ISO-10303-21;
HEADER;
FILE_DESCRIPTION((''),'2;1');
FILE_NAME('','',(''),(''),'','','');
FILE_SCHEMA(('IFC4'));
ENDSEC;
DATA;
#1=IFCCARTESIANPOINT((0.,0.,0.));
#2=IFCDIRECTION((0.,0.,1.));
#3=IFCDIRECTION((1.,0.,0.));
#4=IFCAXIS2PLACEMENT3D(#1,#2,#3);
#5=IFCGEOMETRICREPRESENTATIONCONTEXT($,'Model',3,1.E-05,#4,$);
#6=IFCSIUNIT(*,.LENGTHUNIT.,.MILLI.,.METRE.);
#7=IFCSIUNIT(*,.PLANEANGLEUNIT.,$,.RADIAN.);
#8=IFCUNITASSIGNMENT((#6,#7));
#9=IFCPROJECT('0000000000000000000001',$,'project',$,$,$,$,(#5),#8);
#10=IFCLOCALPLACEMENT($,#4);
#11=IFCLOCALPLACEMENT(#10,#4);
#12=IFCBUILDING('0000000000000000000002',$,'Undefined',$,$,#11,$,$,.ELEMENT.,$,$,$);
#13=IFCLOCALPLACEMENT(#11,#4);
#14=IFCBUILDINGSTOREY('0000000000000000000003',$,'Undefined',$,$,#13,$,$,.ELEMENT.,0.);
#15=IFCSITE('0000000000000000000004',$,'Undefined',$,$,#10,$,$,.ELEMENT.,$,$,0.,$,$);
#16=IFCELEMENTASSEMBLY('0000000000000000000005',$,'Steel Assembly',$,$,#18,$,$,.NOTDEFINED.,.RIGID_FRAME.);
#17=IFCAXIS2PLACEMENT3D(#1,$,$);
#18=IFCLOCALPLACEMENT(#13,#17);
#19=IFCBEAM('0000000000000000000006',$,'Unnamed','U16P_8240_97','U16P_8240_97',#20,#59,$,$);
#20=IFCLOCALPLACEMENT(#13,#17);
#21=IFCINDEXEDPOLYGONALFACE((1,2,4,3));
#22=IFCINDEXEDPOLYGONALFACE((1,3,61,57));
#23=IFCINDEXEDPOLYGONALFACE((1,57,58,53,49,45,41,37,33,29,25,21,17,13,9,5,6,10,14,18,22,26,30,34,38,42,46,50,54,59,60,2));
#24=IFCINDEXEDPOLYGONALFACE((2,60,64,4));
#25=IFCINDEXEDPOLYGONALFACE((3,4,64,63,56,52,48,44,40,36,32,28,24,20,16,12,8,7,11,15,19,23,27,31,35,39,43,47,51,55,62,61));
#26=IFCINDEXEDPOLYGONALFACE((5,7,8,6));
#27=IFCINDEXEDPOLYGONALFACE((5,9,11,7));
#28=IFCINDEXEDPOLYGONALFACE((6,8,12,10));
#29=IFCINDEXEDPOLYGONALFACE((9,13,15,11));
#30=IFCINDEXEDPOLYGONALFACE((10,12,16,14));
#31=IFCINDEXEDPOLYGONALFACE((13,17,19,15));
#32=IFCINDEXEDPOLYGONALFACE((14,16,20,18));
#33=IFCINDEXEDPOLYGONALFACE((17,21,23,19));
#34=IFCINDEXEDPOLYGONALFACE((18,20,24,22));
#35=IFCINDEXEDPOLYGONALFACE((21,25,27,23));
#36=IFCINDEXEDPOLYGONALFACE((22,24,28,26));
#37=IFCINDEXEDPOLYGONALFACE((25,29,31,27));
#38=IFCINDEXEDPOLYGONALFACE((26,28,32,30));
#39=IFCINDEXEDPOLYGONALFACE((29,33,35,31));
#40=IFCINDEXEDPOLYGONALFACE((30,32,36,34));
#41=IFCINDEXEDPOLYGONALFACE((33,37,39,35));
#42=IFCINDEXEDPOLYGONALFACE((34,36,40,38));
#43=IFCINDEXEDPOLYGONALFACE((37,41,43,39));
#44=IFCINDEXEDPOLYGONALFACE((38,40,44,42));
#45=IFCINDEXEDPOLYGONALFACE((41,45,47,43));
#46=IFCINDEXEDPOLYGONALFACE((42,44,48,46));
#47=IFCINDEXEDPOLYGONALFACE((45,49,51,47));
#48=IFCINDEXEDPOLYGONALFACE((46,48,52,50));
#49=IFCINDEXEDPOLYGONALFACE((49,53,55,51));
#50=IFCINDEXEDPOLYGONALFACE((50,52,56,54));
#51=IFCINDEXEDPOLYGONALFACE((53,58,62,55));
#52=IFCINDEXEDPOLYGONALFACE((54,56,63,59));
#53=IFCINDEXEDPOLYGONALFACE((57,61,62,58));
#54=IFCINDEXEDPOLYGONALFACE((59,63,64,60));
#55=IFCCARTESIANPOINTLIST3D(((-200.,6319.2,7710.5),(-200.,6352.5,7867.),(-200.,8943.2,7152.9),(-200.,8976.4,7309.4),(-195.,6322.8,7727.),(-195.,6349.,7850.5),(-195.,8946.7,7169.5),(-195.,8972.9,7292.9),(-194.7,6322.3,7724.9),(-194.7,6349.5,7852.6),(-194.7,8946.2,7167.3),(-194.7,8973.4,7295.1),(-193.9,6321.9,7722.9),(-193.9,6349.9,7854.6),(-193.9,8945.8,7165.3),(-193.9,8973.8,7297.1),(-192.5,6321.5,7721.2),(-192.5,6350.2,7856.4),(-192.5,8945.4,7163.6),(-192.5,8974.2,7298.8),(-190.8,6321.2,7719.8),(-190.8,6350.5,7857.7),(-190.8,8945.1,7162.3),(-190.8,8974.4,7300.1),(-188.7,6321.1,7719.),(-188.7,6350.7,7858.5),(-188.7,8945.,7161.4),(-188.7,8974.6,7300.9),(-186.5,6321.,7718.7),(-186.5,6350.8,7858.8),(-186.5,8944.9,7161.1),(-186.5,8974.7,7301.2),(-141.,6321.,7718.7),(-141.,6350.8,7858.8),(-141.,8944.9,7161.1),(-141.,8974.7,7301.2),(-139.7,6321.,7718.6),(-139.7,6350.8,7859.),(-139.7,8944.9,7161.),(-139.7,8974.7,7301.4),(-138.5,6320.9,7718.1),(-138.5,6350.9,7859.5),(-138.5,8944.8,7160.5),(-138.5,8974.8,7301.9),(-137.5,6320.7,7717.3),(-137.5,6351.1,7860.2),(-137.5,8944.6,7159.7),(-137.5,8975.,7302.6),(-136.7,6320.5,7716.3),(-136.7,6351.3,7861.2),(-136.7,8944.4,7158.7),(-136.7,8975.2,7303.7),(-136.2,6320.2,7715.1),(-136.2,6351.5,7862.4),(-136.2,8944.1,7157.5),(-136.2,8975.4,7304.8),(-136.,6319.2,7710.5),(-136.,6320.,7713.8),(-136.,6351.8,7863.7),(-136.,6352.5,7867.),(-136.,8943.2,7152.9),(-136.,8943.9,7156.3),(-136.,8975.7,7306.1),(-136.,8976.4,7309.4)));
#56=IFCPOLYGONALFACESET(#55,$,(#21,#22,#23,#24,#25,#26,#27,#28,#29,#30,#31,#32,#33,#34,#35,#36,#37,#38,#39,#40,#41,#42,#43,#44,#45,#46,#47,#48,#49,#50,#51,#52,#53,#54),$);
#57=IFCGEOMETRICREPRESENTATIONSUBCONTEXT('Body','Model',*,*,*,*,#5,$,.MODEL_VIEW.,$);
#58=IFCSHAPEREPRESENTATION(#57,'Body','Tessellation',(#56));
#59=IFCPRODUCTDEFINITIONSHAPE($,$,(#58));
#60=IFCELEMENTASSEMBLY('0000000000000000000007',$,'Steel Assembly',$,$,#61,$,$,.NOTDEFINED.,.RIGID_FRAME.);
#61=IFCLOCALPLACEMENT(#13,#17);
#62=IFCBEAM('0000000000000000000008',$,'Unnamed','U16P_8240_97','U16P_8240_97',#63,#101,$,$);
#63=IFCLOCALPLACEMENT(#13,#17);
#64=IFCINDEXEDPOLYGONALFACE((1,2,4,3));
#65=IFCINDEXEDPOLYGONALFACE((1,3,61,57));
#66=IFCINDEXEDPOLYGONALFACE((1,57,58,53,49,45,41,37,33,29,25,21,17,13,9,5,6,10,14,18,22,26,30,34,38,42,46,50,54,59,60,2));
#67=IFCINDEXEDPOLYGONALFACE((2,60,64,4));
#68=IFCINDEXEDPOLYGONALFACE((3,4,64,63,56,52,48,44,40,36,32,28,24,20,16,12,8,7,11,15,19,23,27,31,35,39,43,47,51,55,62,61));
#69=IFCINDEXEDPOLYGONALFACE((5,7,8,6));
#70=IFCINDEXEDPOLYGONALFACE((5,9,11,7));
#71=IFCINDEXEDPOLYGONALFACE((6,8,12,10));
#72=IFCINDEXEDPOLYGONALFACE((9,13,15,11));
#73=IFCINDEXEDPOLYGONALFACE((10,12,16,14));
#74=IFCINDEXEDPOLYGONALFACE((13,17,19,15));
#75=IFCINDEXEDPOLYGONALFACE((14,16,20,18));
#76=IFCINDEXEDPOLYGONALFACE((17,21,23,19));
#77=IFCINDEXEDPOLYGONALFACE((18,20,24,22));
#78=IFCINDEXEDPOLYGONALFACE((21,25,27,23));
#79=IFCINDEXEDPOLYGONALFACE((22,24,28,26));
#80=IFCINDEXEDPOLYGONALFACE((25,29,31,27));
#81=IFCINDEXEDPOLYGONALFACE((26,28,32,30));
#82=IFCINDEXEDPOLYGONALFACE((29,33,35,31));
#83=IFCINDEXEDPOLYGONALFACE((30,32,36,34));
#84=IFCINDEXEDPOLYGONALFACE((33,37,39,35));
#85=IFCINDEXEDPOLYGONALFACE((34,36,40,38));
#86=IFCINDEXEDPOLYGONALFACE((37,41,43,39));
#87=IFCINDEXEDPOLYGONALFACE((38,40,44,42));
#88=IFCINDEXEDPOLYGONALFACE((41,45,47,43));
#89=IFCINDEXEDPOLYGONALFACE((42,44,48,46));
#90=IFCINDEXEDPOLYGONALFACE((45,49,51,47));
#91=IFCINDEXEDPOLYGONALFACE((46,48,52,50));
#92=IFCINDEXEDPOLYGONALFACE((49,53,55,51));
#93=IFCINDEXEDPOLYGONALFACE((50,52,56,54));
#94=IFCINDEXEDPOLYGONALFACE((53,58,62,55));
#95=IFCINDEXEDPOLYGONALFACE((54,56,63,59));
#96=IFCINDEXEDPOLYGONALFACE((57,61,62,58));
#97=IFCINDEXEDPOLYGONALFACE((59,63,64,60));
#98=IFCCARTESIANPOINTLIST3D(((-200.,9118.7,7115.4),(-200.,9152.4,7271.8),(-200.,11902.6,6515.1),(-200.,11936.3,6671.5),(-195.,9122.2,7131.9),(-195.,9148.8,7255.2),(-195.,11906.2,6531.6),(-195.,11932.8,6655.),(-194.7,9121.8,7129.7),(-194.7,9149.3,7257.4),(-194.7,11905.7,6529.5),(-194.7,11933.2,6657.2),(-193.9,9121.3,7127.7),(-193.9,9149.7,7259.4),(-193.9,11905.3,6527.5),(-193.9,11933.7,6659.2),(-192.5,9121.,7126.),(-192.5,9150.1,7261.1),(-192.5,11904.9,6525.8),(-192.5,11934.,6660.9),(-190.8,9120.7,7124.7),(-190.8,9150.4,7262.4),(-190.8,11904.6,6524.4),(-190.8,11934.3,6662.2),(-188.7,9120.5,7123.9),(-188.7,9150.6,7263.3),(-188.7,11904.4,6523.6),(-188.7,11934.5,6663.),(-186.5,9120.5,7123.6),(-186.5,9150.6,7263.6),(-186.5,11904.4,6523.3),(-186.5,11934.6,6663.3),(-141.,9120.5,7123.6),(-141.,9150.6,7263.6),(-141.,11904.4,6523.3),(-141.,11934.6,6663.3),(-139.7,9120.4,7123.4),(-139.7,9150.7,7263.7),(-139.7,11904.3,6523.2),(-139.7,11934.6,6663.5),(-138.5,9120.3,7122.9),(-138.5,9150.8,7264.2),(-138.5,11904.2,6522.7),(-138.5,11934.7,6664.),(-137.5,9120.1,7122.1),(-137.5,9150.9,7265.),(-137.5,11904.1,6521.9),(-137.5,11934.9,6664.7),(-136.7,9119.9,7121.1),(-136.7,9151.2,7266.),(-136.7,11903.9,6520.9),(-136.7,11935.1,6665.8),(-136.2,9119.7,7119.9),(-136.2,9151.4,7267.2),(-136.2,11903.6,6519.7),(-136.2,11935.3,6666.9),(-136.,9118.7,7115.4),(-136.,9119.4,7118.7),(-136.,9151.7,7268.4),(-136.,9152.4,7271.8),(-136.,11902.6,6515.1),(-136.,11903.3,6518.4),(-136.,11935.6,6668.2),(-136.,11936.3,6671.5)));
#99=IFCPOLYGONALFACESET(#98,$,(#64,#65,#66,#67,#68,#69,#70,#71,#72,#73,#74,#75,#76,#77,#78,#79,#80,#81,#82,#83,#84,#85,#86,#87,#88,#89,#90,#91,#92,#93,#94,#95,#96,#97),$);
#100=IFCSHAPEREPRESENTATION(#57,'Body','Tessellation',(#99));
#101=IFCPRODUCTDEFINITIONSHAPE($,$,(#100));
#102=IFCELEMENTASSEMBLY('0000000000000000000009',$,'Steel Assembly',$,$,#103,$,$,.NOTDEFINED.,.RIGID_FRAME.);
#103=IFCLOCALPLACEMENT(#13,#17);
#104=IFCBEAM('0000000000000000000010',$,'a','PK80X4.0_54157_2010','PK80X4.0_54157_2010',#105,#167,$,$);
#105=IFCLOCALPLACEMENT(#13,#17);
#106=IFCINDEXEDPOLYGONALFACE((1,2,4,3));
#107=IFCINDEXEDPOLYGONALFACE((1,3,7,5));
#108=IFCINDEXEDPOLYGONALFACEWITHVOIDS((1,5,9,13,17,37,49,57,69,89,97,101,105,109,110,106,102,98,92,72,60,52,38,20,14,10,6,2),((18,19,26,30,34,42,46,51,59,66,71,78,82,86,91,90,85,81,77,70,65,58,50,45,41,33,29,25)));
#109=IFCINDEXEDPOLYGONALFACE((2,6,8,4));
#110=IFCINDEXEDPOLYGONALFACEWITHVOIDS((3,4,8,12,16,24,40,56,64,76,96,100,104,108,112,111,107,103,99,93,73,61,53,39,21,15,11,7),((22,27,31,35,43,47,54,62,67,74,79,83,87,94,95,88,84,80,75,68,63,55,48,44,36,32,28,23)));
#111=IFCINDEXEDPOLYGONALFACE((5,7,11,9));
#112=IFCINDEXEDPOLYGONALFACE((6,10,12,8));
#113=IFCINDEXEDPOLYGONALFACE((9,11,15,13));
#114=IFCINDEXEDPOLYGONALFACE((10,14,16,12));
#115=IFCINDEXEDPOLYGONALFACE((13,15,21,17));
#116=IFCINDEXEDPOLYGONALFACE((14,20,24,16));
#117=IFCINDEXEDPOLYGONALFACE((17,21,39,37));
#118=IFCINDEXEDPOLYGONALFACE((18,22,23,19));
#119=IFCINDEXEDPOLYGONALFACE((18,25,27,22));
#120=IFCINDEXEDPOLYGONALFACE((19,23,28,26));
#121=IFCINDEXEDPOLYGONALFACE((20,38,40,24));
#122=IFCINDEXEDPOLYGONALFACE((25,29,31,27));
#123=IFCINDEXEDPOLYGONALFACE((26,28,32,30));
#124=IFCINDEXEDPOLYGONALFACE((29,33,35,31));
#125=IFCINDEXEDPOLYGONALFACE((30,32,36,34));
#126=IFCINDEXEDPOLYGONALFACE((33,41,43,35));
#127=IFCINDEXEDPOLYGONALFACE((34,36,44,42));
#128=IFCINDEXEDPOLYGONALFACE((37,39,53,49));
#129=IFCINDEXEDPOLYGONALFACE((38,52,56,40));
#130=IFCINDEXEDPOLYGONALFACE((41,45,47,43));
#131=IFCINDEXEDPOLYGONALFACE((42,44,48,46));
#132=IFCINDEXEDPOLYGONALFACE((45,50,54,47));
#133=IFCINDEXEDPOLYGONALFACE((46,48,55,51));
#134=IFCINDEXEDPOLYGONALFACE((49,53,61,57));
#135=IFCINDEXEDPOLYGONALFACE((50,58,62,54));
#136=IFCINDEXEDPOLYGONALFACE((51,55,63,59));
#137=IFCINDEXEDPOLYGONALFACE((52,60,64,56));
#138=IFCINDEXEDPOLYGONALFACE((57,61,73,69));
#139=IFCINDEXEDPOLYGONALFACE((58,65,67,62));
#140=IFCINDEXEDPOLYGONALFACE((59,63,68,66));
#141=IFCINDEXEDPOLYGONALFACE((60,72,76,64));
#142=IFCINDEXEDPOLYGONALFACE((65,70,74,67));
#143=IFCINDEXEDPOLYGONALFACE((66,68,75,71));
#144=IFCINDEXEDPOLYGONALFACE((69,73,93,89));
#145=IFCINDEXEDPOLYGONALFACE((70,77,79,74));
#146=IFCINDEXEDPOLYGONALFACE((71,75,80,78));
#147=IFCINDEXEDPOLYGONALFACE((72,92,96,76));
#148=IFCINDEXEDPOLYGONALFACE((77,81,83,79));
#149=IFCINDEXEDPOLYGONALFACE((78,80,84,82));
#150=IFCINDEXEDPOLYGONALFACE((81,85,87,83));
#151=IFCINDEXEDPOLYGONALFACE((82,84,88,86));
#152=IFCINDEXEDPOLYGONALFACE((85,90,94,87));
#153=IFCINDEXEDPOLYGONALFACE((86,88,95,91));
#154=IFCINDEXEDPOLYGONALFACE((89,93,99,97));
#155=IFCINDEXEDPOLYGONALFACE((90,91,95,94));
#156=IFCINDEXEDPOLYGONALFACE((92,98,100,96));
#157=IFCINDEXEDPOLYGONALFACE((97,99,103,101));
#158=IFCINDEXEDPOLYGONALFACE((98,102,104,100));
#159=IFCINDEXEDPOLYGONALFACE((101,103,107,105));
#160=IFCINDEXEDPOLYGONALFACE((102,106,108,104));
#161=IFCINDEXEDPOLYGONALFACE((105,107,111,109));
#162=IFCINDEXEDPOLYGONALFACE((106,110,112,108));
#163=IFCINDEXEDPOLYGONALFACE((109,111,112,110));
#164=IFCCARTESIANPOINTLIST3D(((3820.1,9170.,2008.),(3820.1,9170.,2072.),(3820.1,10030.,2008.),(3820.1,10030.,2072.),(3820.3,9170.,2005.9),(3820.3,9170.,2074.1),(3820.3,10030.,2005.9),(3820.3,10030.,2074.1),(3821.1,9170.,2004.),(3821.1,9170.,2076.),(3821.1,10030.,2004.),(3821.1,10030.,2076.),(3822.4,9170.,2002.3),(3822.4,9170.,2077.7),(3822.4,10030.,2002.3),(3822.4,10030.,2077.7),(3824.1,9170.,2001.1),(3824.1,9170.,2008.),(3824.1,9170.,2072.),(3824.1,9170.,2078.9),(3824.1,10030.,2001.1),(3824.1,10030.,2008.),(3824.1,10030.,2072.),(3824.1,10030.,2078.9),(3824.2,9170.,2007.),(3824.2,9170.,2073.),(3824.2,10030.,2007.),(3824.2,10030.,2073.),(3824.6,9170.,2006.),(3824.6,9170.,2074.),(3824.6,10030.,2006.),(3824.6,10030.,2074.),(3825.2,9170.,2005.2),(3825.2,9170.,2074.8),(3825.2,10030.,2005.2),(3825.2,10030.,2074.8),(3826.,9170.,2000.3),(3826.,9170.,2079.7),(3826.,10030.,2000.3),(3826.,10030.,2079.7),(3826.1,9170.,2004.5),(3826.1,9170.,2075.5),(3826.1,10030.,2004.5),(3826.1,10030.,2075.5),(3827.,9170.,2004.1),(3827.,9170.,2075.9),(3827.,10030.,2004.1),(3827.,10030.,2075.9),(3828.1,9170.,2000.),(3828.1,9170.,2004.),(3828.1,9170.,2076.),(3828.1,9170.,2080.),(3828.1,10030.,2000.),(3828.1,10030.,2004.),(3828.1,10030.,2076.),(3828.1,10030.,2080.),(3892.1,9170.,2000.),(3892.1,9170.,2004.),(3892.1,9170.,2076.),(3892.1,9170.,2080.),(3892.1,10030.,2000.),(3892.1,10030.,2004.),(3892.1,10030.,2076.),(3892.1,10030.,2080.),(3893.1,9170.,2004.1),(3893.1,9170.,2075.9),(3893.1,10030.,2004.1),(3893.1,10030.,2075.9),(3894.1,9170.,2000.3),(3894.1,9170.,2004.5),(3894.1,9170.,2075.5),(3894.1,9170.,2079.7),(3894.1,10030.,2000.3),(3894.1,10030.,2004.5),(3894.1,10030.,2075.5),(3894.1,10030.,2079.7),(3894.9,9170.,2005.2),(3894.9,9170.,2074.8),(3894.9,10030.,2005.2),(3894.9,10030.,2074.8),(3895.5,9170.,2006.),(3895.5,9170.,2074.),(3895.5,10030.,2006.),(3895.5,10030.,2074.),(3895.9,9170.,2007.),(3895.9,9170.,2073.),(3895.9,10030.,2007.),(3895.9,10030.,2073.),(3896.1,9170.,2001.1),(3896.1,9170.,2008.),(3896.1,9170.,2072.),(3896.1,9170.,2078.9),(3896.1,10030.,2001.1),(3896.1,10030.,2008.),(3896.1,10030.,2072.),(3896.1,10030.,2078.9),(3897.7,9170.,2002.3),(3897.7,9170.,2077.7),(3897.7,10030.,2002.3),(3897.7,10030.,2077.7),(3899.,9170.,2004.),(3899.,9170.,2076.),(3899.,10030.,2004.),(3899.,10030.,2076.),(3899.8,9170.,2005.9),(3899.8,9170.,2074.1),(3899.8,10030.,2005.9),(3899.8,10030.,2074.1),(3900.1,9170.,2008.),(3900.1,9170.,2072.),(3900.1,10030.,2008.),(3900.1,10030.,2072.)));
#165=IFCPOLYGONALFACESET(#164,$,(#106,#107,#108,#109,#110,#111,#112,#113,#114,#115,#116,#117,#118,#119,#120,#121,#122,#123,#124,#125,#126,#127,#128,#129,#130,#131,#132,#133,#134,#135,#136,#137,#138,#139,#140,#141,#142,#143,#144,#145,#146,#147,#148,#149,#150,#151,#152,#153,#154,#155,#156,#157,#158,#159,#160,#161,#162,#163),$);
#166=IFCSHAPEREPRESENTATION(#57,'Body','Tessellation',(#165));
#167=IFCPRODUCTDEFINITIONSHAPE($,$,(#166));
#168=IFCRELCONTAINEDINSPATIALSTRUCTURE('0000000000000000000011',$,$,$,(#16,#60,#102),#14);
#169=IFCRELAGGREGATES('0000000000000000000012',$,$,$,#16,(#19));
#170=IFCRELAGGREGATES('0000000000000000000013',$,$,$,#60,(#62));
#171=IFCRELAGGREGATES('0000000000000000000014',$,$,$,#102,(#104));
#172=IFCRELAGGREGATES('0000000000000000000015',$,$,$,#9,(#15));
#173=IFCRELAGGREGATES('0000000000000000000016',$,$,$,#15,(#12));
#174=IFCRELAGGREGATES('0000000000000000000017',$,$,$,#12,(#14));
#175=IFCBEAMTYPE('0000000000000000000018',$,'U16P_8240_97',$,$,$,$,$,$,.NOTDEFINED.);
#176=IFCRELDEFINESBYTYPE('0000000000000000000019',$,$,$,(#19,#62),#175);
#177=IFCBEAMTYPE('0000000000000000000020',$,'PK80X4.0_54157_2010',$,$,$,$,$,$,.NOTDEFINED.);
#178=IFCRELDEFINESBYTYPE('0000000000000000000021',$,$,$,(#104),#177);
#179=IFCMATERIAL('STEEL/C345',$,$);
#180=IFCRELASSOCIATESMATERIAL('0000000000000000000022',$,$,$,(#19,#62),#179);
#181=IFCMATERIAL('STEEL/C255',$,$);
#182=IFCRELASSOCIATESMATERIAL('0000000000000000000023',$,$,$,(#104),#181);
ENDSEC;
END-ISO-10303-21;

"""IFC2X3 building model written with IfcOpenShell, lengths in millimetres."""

from ifc_helpers import new_model, si_unit, frame, origin_with_axes, origin_2d_with_axis, place, context, subcontext, project, spatial, hollow_rectangle, u_section, extrude, material, type_object, element, aggregate, save


model = new_model("IFC2X3")

# Units and contexts
model_context = context("Model", 3, precision=1e-05, world=origin_with_axes())
body_context = subcontext(model_context, "Body", "Model", "MODEL_VIEW")
ifc_project = project(units=[si_unit("LENGTHUNIT", "METRE", prefix="MILLI"), si_unit("PLANEANGLEUNIT", "RADIAN")], contexts=[model_context])

# Site, building, storey
site_placement = place(None, origin_with_axes())
site = spatial("IfcSite", under=ifc_project, at=site_placement, Name="Undefined", CompositionType="ELEMENT", RefElevation=0.0)
building_placement = place(site_placement, origin_with_axes())
building = spatial("IfcBuilding", under=site, at=building_placement, Name="Undefined", CompositionType="ELEMENT")
storey_placement = place(building_placement, origin_with_axes())
storey = spatial("IfcBuildingStorey", under=building, at=storey_placement, Name="Undefined", CompositionType="ELEMENT", Elevation=0.0)

# Element assemblies, beams
assembly_1_placement = place(storey_placement, origin_with_axes())
assembly_1 = element("IfcElementAssembly", 1, at=assembly_1_placement, inside=storey, Name="Steel Assembly", AssemblyPlace="NOTDEFINED", PredefinedType="RIGID_FRAME")
ifc_material_1 = material(Name="STEEL/C345")
beam_type_1 = type_object("IfcBeamType", Name="U16P_8240_97", PredefinedType="NOTDEFINED")
beam_1_placement = place(assembly_1_placement, frame((-168.0, 6335.9, 7788.8), z_axis=(0.0, 0.207859, 0.978159), x_axis=(0.0, 0.978159, -0.207859)))
beam_1 = element("IfcBeam", 2, at=beam_1_placement, type_object=beam_type_1, material=ifc_material_1, Name="Unnamed", Description="U16P_8240_97", ObjectType="U16P_8240_97", context=body_context, shape_type="SweptSolid", body=[
    extrude(u_section(Depth=160.0, FlangeWidth=64.0, WebThickness=5.0, FlangeThickness=8.4, FilletRadius=8.5, EdgeRadius=5.0, at=origin_2d_with_axis()), frame((2682.5, 0.0, 0.0), z_axis=(-1.0, 0.0, 0.0), x_axis=(0.0, -1.0, 0.0)), (0.0, 0.0, 1.0), 2682.5),
])
aggregate(assembly_1, [beam_1])
assembly_2_placement = place(storey_placement, origin_with_axes())
assembly_2 = element("IfcElementAssembly", 3, at=assembly_2_placement, inside=storey, Name="Steel Assembly", AssemblyPlace="NOTDEFINED", PredefinedType="RIGID_FRAME")
beam_2_placement = place(assembly_2_placement, frame((-168.0, 9135.6, 7193.6), z_axis=(0.0, 0.210765, 0.977537), x_axis=(0.0, 0.977537, -0.210765)))
beam_2 = element("IfcBeam", 4, at=beam_2_placement, type_object=beam_type_1, material=ifc_material_1, Name="Unnamed", Description="U16P_8240_97", ObjectType="U16P_8240_97", context=body_context, shape_type="SweptSolid", body=[
    extrude(u_section(Depth=160.0, FlangeWidth=64.0, WebThickness=5.0, FlangeThickness=8.4, FilletRadius=8.5, EdgeRadius=5.0, at=origin_2d_with_axis()), frame((2847.9, 0.0, 0.0), z_axis=(-1.0, 0.0, 0.0), x_axis=(0.0, -1.0, 0.0)), (0.0, 0.0, 1.0), 2847.9),
])
aggregate(assembly_2, [beam_2])
assembly_3_placement = place(storey_placement, origin_with_axes())
assembly_3 = element("IfcElementAssembly", 5, at=assembly_3_placement, inside=storey, Name="Steel Assembly", AssemblyPlace="NOTDEFINED", PredefinedType="RIGID_FRAME")
ifc_material_2 = material(Name="STEEL/C255")
beam_type_2 = type_object("IfcBeamType", Name="PK80X4.0_54157_2010", PredefinedType="NOTDEFINED")
beam_3_placement = place(assembly_3_placement, frame((3860.1, 9170.0, 2040.0), z_axis=(0.0, 0.0, 1.0), x_axis=(0.0, 1.0, 0.0)))
beam_3 = element("IfcBeam", 6, at=beam_3_placement, type_object=beam_type_2, material=ifc_material_2, Name="a", Description="PK80X4.0_54157_2010", ObjectType="PK80X4.0_54157_2010", context=body_context, shape_type="SweptSolid", body=[
    extrude(hollow_rectangle(XDim=80.0, YDim=80.0, WallThickness=4.0, InnerFilletRadius=4.0, OuterFilletRadius=8.0, at=origin_2d_with_axis()), frame((860.0, 0.0, 0.0), z_axis=(-1.0, 0.0, 0.0), x_axis=(0.0, -1.0, 0.0)), (0.0, 0.0, 1.0), 860.0),
])
aggregate(assembly_3, [beam_3])

save(model, "model.ifc")
